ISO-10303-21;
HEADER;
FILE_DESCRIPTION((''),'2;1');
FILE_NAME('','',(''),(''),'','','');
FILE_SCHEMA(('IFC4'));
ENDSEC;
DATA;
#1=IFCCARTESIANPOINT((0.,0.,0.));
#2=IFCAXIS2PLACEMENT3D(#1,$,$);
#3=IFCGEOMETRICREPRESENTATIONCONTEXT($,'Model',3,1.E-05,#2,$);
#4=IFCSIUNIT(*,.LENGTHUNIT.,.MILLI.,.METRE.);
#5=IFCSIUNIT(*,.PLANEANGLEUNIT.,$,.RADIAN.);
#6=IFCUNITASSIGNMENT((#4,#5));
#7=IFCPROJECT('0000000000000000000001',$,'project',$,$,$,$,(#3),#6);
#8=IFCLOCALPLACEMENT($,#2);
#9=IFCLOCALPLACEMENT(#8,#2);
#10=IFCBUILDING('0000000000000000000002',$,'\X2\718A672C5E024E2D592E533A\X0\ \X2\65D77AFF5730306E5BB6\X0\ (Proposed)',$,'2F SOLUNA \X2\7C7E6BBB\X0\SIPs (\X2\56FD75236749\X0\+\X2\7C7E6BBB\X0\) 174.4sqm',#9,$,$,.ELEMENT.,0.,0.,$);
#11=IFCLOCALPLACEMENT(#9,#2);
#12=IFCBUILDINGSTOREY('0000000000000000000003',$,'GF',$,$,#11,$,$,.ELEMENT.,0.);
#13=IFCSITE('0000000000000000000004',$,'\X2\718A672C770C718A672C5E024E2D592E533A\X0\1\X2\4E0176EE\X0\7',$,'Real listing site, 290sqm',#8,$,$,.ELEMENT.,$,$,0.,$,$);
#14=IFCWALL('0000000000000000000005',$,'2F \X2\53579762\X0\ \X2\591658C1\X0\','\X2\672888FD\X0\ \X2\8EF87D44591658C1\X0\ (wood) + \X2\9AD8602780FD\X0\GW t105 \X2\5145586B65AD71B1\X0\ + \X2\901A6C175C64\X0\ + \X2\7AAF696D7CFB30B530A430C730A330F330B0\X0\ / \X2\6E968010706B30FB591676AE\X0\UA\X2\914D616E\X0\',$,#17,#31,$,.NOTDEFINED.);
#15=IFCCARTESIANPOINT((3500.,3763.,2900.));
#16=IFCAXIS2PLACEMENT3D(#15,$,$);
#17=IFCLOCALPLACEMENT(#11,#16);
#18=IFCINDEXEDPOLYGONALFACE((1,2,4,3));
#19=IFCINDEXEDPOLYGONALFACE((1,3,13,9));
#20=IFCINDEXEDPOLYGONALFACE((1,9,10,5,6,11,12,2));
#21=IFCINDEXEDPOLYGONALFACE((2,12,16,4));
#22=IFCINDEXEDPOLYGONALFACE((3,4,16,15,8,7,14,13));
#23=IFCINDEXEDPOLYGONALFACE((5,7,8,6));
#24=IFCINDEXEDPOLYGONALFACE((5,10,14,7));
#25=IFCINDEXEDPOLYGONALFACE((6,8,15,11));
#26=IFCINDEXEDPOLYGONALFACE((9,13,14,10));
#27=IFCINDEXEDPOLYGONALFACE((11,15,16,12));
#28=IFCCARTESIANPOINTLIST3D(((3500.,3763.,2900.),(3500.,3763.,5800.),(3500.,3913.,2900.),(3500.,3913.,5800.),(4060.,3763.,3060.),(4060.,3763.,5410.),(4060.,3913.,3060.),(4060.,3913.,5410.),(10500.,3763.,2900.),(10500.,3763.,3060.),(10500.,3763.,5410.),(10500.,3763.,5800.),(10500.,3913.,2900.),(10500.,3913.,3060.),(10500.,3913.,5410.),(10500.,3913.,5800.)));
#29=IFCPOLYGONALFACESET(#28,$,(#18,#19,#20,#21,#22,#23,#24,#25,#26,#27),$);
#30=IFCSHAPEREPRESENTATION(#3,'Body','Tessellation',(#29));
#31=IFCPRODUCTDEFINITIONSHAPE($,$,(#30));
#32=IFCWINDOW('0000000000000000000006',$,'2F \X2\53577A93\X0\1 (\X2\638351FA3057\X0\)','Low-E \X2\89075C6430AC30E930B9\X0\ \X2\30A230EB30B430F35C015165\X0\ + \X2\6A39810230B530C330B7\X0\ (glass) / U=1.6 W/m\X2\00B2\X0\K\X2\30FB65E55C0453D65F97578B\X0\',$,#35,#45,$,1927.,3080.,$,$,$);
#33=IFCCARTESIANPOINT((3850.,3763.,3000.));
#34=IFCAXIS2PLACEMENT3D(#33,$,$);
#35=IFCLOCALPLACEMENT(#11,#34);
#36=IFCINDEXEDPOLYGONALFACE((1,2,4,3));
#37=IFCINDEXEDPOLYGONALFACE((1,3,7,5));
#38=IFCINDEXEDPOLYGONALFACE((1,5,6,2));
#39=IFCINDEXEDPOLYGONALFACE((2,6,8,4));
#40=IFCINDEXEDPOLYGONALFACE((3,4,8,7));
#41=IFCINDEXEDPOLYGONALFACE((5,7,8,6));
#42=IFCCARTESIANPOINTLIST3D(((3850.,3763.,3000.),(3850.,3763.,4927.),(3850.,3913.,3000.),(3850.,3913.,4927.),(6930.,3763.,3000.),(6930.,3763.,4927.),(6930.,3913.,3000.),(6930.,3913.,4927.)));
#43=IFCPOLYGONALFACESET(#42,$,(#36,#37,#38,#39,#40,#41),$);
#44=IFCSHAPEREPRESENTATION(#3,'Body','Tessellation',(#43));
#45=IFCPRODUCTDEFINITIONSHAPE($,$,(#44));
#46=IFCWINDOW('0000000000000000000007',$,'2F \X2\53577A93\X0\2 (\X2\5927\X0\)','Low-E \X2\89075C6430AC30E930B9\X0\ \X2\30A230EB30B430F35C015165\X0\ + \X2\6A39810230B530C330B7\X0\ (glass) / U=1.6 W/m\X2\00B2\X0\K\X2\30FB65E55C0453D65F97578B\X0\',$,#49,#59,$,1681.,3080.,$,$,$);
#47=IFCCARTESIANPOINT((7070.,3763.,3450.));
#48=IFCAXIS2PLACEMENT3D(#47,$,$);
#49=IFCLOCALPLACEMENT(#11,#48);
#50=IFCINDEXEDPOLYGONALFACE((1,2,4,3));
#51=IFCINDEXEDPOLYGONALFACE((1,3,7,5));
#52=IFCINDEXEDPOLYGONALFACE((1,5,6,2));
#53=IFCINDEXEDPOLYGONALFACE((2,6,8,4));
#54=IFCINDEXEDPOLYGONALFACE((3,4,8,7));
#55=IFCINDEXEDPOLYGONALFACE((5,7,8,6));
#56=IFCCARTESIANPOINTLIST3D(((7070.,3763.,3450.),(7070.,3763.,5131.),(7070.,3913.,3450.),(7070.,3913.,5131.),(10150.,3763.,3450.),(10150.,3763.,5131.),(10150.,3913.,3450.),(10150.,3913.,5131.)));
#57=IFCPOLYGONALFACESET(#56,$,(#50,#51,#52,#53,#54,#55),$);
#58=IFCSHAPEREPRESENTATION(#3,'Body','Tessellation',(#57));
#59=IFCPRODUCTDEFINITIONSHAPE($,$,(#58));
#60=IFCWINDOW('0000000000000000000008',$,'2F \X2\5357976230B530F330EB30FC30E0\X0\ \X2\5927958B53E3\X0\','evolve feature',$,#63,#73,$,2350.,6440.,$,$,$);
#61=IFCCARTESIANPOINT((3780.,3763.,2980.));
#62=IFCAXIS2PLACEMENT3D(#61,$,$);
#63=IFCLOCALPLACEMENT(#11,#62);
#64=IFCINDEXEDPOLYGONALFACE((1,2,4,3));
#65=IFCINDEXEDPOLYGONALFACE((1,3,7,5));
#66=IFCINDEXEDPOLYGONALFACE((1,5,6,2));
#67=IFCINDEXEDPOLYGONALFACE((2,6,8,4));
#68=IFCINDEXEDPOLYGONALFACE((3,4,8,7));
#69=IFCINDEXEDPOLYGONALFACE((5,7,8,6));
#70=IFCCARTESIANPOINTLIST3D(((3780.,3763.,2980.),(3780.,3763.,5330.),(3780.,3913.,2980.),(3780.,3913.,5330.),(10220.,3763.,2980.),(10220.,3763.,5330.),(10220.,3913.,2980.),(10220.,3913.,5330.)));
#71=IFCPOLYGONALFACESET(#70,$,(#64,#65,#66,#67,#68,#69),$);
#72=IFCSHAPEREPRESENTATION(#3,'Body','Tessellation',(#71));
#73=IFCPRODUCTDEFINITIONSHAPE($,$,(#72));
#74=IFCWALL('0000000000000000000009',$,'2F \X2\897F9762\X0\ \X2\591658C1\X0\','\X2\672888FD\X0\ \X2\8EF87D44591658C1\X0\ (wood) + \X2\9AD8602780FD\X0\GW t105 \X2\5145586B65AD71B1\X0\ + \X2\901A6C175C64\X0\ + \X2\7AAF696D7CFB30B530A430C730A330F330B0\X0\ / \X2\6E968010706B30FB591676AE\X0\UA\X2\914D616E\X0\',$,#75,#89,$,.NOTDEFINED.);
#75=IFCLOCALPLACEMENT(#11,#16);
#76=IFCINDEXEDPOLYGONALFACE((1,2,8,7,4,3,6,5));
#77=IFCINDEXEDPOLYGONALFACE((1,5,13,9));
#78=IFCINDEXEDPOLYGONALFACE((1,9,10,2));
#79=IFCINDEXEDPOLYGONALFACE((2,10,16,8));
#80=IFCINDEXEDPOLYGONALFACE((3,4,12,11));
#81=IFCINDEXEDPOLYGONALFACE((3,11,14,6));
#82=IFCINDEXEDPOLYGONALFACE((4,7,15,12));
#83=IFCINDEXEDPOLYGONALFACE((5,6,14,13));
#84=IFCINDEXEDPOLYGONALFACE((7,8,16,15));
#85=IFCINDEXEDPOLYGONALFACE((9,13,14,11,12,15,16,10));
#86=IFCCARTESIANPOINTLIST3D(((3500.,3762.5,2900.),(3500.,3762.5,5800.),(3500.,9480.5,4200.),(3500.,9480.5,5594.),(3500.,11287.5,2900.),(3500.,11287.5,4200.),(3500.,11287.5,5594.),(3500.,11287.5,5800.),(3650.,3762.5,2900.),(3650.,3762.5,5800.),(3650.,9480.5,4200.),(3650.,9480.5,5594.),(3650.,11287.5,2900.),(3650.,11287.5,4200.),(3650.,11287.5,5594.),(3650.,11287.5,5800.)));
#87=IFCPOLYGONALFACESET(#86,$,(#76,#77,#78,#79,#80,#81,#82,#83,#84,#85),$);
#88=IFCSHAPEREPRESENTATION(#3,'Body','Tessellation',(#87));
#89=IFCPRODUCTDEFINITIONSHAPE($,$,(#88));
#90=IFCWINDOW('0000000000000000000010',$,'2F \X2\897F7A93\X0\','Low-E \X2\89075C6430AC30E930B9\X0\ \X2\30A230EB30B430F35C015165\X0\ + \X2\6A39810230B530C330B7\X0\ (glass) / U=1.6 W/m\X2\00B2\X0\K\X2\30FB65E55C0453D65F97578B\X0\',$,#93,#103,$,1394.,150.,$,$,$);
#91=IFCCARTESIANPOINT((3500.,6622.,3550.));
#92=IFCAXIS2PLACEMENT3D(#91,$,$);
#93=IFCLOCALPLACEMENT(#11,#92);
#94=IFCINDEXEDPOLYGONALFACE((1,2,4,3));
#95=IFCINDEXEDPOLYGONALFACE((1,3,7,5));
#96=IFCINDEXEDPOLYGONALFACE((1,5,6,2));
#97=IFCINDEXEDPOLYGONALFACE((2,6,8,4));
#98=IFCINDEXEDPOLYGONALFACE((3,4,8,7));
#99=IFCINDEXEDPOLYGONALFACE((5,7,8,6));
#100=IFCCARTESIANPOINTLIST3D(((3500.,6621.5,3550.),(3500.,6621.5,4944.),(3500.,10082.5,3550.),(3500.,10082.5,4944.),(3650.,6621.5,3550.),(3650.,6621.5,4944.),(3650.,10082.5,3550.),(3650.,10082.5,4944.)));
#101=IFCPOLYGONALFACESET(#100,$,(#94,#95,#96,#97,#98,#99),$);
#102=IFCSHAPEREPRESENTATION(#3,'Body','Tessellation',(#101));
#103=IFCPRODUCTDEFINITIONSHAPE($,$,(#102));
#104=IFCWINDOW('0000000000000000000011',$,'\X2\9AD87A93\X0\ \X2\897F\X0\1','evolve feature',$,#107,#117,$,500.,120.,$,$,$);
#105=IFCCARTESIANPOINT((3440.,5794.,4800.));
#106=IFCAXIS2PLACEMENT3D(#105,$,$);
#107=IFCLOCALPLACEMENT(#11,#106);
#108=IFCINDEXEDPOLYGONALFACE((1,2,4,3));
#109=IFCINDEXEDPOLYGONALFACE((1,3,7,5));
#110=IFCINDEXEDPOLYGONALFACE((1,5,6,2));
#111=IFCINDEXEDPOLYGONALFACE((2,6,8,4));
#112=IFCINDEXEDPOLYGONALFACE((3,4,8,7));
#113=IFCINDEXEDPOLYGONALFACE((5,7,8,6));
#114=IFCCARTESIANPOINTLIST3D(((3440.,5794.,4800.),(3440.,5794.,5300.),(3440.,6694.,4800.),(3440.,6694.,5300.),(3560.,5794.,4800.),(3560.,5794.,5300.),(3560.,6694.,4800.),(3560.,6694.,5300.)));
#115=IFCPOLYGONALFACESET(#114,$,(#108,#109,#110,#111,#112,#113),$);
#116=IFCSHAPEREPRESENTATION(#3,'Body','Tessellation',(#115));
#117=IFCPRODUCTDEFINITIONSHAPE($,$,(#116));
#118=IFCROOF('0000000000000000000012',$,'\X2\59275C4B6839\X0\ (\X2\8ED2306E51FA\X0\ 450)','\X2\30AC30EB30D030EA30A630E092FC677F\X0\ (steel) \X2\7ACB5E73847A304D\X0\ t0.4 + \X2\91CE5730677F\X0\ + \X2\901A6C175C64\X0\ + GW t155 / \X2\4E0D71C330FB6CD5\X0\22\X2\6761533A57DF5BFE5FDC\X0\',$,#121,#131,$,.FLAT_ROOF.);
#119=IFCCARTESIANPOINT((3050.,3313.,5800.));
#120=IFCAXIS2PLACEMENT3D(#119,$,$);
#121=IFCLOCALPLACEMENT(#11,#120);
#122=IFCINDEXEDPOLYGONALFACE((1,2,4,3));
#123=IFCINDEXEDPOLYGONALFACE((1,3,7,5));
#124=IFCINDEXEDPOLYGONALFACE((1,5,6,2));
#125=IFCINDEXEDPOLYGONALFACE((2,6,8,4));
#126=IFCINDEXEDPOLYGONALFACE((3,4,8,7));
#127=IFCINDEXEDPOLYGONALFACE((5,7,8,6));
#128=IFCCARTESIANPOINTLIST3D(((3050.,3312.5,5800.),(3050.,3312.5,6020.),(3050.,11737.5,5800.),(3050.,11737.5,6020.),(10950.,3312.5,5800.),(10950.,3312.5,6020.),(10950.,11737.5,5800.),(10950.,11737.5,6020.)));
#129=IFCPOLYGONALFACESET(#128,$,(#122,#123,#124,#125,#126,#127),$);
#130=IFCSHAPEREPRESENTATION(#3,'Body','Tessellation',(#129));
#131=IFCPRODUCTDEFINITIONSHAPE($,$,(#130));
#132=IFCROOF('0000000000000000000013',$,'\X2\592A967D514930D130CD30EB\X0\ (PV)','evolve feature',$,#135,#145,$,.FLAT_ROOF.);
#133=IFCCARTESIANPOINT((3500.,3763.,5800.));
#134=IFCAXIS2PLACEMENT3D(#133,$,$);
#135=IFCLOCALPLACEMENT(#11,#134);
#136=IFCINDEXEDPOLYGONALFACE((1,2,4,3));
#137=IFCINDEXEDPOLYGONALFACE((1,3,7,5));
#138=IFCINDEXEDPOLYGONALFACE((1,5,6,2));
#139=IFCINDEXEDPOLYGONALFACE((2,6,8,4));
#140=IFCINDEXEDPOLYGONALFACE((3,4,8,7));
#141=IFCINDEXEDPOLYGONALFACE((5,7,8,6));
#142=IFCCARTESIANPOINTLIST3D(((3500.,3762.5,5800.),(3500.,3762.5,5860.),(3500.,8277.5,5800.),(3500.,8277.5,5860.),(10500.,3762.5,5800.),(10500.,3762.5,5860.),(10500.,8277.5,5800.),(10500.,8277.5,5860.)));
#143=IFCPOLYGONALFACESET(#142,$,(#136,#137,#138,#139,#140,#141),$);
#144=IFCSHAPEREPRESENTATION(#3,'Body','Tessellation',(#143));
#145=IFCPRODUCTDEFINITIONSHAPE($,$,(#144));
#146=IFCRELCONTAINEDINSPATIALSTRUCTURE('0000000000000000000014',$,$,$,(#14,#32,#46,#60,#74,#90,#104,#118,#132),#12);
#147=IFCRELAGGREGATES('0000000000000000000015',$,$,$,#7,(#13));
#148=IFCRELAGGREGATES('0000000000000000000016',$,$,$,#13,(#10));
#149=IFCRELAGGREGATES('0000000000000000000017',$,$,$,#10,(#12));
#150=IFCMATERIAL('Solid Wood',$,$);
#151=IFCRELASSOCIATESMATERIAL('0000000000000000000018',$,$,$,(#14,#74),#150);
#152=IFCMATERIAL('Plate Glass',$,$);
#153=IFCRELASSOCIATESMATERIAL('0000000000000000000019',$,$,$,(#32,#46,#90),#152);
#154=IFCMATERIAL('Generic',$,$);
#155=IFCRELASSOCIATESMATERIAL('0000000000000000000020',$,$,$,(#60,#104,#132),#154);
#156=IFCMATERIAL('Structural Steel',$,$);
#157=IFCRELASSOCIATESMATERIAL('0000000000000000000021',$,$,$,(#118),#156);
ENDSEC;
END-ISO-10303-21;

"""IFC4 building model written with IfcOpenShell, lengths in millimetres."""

from ifc_helpers import new_model, si_unit, frame, frame_2d, origin, place, context, project, spatial, rectangle, extrude, material, element, fill, save


model = new_model("IFC4")

# Units and contexts
model_context = context("Model", 3, precision=1e-05, world=origin())
ifc_project = project(units=[si_unit("LENGTHUNIT", "METRE", prefix="MILLI"), si_unit("PLANEANGLEUNIT", "RADIAN")], contexts=[model_context])

# Site, building, storey
site_placement = place(None, origin())
site = spatial("IfcSite", under=ifc_project, at=site_placement, Name="熊本県熊本市中央区1丁目7", ObjectType="Real listing site, 290sqm", CompositionType="ELEMENT", RefElevation=0.0)
building_placement = place(site_placement, origin())
building = spatial("IfcBuilding", under=site, at=building_placement, Name="熊本市中央区 旗竿地の家 (Proposed)", ObjectType="2F SOLUNA 籾殻SIPs (国産杉+籾殻) 174.4sqm", CompositionType="ELEMENT", ElevationOfRefHeight=0.0, ElevationOfTerrain=0.0)
storey_placement = place(building_placement, origin())
storey = spatial("IfcBuildingStorey", under=building, at=storey_placement, Name="GF", CompositionType="ELEMENT", Elevation=0.0)

# Shared definitions
ifc_material_1 = material(Name="Solid Wood")
ifc_material_2 = material(Name="Generic")

# Shared definitions
ifc_material_3 = material(Name="Plate Glass")

# Walls, openings, windows
wall_1_placement = place(storey_placement, frame((3500.0, 3763.0, 2900.0)))
wall_1 = element("IfcWall", 1, at=wall_1_placement, inside=storey, material=ifc_material_1, Name="2F 南面 外壁", Description="木製 軸組外壁 (wood) + 高性能GW t105 充填断熱 + 通気層 + 窯業系サイディング / 準耐火・外皮UA配慮", PredefinedType="NOTDEFINED", context=model_context, shape_type="SweptSolid", body=[
    extrude(rectangle(XDim=7000.0, YDim=150.0, at=frame_2d((3500.0, 75.0))), frame((3500.0, 3763.0, 2900.0)), (0.0, 0.0, 1.0), 2900.0),
])
opening_1_placement = place(storey_placement, frame((3850.0, 3763.0, 3000.0)))
opening_1 = element("IfcOpeningElement", 2, at=opening_1_placement, cuts=wall_1, PredefinedType="NOTDEFINED", context=model_context, shape_type="SweptSolid", body=[
    extrude(rectangle(XDim=3080.0, YDim=150.0, at=frame_2d((1540.0, 75.0))), frame((3850.0, 3763.0, 3000.0)), (0.0, 0.0, 1.0), 1927.0),
])
opening_2_placement = place(storey_placement, frame((7070.0, 3763.0, 3450.0)))
opening_2 = element("IfcOpeningElement", 3, at=opening_2_placement, cuts=wall_1, PredefinedType="NOTDEFINED", context=model_context, shape_type="SweptSolid", body=[
    extrude(rectangle(XDim=3080.0, YDim=150.0, at=frame_2d((1540.0, 75.0))), frame((7070.0, 3763.0, 3450.0)), (0.0, 0.0, 1.0), 1681.0),
])
opening_3_placement = place(storey_placement, frame((3780.0, 3763.0, 2980.0)))
opening_3 = element("IfcOpeningElement", 4, at=opening_3_placement, cuts=wall_1, PredefinedType="NOTDEFINED", context=model_context, shape_type="SweptSolid", body=[
    extrude(rectangle(XDim=6440.0, YDim=150.0, at=frame_2d((3220.0, 75.0))), frame((3780.0, 3763.0, 2980.0)), (0.0, 0.0, 1.0), 2350.0),
])
window_1_placement = place(storey_placement, frame((3850.0, 3763.0, 3000.0)))
window_1 = element("IfcWindow", 5, at=window_1_placement, inside=storey, material=ifc_material_3, Name="2F 南窓1 (掃出し)", Description="Low-E 複層ガラス アルゴン封入 + 樹脂サッシ (glass) / U=1.6 W/m²K・日射取得型", OverallHeight=1927.0, OverallWidth=3080.0, context=model_context, shape_type="SweptSolid", body=[
    extrude(rectangle(XDim=3080.0, YDim=150.0, at=frame_2d((1540.0, 75.0))), frame((3850.0, 3763.0, 3000.0)), (0.0, 0.0, 1.0), 1927.0),
])
fill(opening_1, window_1)
window_2_placement = place(storey_placement, frame((7070.0, 3763.0, 3450.0)))
window_2 = element("IfcWindow", 6, at=window_2_placement, inside=storey, material=ifc_material_3, Name="2F 南窓2 (大)", Description="Low-E 複層ガラス アルゴン封入 + 樹脂サッシ (glass) / U=1.6 W/m²K・日射取得型", OverallHeight=1681.0, OverallWidth=3080.0, context=model_context, shape_type="SweptSolid", body=[
    extrude(rectangle(XDim=3080.0, YDim=150.0, at=frame_2d((1540.0, 75.0))), frame((7070.0, 3763.0, 3450.0)), (0.0, 0.0, 1.0), 1681.0),
])
fill(opening_2, window_2)
window_3_placement = place(storey_placement, frame((3780.0, 3763.0, 2980.0)))
window_3 = element("IfcWindow", 7, at=window_3_placement, inside=storey, material=ifc_material_2, Name="2F 南面サンルーム 大開口", Description="evolve feature", OverallHeight=2350.0, OverallWidth=6440.0, context=model_context, shape_type="SweptSolid", body=[
    extrude(rectangle(XDim=6440.0, YDim=150.0, at=frame_2d((3220.0, 75.0))), frame((3780.0, 3763.0, 2980.0)), (0.0, 0.0, 1.0), 2350.0),
])
fill(opening_3, window_3)
wall_2_placement = place(storey_placement, frame((3500.0, 3763.0, 2900.0)))
wall_2 = element("IfcWall", 8, at=wall_2_placement, inside=storey, material=ifc_material_1, Name="2F 西面 外壁", Description="木製 軸組外壁 (wood) + 高性能GW t105 充填断熱 + 通気層 + 窯業系サイディング / 準耐火・外皮UA配慮", PredefinedType="NOTDEFINED", context=model_context, shape_type="SweptSolid", body=[
    extrude(rectangle(XDim=150.0, YDim=7525.0, at=frame_2d((75.0, 3762.0))), frame((3500.0, 3763.0, 2900.0)), (0.0, 0.0, 1.0), 2900.0),
])
opening_4_placement = place(storey_placement, frame((3500.0, 6622.0, 3550.0)))
opening_4 = element("IfcOpeningElement", 9, at=opening_4_placement, cuts=wall_2, PredefinedType="NOTDEFINED", context=model_context, shape_type="SweptSolid", body=[
    extrude(rectangle(XDim=150.0, YDim=3461.0, at=frame_2d((75.0, 1730.0))), frame((3500.0, 6622.0, 3550.0)), (0.0, 0.0, 1.0), 1394.0),
])
opening_5_placement = place(storey_placement, frame((3440.0, 5794.0, 4800.0)))
opening_5 = element("IfcOpeningElement", 10, at=opening_5_placement, cuts=wall_2, PredefinedType="NOTDEFINED", context=model_context, shape_type="SweptSolid", body=[
    extrude(rectangle(XDim=120.0, YDim=900.0, at=frame_2d((60.0, 450.0))), frame((3440.0, 5794.0, 4800.0)), (0.0, 0.0, 1.0), 500.0),
])
window_4_placement = place(storey_placement, frame((3500.0, 6622.0, 3550.0)))
window_4 = element("IfcWindow", 11, at=window_4_placement, inside=storey, material=ifc_material_3, Name="2F 西窓", Description="Low-E 複層ガラス アルゴン封入 + 樹脂サッシ (glass) / U=1.6 W/m²K・日射取得型", OverallHeight=1394.0, OverallWidth=150.0, context=model_context, shape_type="SweptSolid", body=[
    extrude(rectangle(XDim=150.0, YDim=3461.0, at=frame_2d((75.0, 1730.0))), frame((3500.0, 6622.0, 3550.0)), (0.0, 0.0, 1.0), 1394.0),
])
fill(opening_4, window_4)
window_5_placement = place(storey_placement, frame((3440.0, 5794.0, 4800.0)))
window_5 = element("IfcWindow", 12, at=window_5_placement, inside=storey, material=ifc_material_2, Name="高窓 西1", Description="evolve feature", OverallHeight=500.0, OverallWidth=120.0, context=model_context, shape_type="SweptSolid", body=[
    extrude(rectangle(XDim=120.0, YDim=900.0, at=frame_2d((60.0, 450.0))), frame((3440.0, 5794.0, 4800.0)), (0.0, 0.0, 1.0), 500.0),
])
fill(opening_5, window_5)

# Roofs
ifc_material_4 = material(Name="Structural Steel")
roof_1_placement = place(storey_placement, frame((3050.0, 3313.0, 5800.0)))
element("IfcRoof", 13, at=roof_1_placement, inside=storey, material=ifc_material_4, Name="大屋根 (軒の出 450)", Description="ガルバリウム鋼板 (steel) 立平葺き t0.4 + 野地板 + 通気層 + GW t155 / 不燃・法22条区域対応", PredefinedType="FLAT_ROOF", context=model_context, shape_type="SweptSolid", body=[
    extrude(rectangle(XDim=7900.0, YDim=8425.0, at=frame_2d((3950.0, 4212.0))), frame((3050.0, 3313.0, 5800.0)), (0.0, 0.0, 1.0), 220.0),
])
roof_2_placement = place(storey_placement, frame((3500.0, 3763.0, 5800.0)))
element("IfcRoof", 14, at=roof_2_placement, inside=storey, material=ifc_material_2, Name="太陽光パネル (PV)", Description="evolve feature", PredefinedType="FLAT_ROOF", context=model_context, shape_type="SweptSolid", body=[
    extrude(rectangle(XDim=7000.0, YDim=4515.0, at=frame_2d((3500.0, 2257.0))), frame((3500.0, 3763.0, 5800.0)), (0.0, 0.0, 1.0), 60.0),
])

save(model, "model.ifc")
